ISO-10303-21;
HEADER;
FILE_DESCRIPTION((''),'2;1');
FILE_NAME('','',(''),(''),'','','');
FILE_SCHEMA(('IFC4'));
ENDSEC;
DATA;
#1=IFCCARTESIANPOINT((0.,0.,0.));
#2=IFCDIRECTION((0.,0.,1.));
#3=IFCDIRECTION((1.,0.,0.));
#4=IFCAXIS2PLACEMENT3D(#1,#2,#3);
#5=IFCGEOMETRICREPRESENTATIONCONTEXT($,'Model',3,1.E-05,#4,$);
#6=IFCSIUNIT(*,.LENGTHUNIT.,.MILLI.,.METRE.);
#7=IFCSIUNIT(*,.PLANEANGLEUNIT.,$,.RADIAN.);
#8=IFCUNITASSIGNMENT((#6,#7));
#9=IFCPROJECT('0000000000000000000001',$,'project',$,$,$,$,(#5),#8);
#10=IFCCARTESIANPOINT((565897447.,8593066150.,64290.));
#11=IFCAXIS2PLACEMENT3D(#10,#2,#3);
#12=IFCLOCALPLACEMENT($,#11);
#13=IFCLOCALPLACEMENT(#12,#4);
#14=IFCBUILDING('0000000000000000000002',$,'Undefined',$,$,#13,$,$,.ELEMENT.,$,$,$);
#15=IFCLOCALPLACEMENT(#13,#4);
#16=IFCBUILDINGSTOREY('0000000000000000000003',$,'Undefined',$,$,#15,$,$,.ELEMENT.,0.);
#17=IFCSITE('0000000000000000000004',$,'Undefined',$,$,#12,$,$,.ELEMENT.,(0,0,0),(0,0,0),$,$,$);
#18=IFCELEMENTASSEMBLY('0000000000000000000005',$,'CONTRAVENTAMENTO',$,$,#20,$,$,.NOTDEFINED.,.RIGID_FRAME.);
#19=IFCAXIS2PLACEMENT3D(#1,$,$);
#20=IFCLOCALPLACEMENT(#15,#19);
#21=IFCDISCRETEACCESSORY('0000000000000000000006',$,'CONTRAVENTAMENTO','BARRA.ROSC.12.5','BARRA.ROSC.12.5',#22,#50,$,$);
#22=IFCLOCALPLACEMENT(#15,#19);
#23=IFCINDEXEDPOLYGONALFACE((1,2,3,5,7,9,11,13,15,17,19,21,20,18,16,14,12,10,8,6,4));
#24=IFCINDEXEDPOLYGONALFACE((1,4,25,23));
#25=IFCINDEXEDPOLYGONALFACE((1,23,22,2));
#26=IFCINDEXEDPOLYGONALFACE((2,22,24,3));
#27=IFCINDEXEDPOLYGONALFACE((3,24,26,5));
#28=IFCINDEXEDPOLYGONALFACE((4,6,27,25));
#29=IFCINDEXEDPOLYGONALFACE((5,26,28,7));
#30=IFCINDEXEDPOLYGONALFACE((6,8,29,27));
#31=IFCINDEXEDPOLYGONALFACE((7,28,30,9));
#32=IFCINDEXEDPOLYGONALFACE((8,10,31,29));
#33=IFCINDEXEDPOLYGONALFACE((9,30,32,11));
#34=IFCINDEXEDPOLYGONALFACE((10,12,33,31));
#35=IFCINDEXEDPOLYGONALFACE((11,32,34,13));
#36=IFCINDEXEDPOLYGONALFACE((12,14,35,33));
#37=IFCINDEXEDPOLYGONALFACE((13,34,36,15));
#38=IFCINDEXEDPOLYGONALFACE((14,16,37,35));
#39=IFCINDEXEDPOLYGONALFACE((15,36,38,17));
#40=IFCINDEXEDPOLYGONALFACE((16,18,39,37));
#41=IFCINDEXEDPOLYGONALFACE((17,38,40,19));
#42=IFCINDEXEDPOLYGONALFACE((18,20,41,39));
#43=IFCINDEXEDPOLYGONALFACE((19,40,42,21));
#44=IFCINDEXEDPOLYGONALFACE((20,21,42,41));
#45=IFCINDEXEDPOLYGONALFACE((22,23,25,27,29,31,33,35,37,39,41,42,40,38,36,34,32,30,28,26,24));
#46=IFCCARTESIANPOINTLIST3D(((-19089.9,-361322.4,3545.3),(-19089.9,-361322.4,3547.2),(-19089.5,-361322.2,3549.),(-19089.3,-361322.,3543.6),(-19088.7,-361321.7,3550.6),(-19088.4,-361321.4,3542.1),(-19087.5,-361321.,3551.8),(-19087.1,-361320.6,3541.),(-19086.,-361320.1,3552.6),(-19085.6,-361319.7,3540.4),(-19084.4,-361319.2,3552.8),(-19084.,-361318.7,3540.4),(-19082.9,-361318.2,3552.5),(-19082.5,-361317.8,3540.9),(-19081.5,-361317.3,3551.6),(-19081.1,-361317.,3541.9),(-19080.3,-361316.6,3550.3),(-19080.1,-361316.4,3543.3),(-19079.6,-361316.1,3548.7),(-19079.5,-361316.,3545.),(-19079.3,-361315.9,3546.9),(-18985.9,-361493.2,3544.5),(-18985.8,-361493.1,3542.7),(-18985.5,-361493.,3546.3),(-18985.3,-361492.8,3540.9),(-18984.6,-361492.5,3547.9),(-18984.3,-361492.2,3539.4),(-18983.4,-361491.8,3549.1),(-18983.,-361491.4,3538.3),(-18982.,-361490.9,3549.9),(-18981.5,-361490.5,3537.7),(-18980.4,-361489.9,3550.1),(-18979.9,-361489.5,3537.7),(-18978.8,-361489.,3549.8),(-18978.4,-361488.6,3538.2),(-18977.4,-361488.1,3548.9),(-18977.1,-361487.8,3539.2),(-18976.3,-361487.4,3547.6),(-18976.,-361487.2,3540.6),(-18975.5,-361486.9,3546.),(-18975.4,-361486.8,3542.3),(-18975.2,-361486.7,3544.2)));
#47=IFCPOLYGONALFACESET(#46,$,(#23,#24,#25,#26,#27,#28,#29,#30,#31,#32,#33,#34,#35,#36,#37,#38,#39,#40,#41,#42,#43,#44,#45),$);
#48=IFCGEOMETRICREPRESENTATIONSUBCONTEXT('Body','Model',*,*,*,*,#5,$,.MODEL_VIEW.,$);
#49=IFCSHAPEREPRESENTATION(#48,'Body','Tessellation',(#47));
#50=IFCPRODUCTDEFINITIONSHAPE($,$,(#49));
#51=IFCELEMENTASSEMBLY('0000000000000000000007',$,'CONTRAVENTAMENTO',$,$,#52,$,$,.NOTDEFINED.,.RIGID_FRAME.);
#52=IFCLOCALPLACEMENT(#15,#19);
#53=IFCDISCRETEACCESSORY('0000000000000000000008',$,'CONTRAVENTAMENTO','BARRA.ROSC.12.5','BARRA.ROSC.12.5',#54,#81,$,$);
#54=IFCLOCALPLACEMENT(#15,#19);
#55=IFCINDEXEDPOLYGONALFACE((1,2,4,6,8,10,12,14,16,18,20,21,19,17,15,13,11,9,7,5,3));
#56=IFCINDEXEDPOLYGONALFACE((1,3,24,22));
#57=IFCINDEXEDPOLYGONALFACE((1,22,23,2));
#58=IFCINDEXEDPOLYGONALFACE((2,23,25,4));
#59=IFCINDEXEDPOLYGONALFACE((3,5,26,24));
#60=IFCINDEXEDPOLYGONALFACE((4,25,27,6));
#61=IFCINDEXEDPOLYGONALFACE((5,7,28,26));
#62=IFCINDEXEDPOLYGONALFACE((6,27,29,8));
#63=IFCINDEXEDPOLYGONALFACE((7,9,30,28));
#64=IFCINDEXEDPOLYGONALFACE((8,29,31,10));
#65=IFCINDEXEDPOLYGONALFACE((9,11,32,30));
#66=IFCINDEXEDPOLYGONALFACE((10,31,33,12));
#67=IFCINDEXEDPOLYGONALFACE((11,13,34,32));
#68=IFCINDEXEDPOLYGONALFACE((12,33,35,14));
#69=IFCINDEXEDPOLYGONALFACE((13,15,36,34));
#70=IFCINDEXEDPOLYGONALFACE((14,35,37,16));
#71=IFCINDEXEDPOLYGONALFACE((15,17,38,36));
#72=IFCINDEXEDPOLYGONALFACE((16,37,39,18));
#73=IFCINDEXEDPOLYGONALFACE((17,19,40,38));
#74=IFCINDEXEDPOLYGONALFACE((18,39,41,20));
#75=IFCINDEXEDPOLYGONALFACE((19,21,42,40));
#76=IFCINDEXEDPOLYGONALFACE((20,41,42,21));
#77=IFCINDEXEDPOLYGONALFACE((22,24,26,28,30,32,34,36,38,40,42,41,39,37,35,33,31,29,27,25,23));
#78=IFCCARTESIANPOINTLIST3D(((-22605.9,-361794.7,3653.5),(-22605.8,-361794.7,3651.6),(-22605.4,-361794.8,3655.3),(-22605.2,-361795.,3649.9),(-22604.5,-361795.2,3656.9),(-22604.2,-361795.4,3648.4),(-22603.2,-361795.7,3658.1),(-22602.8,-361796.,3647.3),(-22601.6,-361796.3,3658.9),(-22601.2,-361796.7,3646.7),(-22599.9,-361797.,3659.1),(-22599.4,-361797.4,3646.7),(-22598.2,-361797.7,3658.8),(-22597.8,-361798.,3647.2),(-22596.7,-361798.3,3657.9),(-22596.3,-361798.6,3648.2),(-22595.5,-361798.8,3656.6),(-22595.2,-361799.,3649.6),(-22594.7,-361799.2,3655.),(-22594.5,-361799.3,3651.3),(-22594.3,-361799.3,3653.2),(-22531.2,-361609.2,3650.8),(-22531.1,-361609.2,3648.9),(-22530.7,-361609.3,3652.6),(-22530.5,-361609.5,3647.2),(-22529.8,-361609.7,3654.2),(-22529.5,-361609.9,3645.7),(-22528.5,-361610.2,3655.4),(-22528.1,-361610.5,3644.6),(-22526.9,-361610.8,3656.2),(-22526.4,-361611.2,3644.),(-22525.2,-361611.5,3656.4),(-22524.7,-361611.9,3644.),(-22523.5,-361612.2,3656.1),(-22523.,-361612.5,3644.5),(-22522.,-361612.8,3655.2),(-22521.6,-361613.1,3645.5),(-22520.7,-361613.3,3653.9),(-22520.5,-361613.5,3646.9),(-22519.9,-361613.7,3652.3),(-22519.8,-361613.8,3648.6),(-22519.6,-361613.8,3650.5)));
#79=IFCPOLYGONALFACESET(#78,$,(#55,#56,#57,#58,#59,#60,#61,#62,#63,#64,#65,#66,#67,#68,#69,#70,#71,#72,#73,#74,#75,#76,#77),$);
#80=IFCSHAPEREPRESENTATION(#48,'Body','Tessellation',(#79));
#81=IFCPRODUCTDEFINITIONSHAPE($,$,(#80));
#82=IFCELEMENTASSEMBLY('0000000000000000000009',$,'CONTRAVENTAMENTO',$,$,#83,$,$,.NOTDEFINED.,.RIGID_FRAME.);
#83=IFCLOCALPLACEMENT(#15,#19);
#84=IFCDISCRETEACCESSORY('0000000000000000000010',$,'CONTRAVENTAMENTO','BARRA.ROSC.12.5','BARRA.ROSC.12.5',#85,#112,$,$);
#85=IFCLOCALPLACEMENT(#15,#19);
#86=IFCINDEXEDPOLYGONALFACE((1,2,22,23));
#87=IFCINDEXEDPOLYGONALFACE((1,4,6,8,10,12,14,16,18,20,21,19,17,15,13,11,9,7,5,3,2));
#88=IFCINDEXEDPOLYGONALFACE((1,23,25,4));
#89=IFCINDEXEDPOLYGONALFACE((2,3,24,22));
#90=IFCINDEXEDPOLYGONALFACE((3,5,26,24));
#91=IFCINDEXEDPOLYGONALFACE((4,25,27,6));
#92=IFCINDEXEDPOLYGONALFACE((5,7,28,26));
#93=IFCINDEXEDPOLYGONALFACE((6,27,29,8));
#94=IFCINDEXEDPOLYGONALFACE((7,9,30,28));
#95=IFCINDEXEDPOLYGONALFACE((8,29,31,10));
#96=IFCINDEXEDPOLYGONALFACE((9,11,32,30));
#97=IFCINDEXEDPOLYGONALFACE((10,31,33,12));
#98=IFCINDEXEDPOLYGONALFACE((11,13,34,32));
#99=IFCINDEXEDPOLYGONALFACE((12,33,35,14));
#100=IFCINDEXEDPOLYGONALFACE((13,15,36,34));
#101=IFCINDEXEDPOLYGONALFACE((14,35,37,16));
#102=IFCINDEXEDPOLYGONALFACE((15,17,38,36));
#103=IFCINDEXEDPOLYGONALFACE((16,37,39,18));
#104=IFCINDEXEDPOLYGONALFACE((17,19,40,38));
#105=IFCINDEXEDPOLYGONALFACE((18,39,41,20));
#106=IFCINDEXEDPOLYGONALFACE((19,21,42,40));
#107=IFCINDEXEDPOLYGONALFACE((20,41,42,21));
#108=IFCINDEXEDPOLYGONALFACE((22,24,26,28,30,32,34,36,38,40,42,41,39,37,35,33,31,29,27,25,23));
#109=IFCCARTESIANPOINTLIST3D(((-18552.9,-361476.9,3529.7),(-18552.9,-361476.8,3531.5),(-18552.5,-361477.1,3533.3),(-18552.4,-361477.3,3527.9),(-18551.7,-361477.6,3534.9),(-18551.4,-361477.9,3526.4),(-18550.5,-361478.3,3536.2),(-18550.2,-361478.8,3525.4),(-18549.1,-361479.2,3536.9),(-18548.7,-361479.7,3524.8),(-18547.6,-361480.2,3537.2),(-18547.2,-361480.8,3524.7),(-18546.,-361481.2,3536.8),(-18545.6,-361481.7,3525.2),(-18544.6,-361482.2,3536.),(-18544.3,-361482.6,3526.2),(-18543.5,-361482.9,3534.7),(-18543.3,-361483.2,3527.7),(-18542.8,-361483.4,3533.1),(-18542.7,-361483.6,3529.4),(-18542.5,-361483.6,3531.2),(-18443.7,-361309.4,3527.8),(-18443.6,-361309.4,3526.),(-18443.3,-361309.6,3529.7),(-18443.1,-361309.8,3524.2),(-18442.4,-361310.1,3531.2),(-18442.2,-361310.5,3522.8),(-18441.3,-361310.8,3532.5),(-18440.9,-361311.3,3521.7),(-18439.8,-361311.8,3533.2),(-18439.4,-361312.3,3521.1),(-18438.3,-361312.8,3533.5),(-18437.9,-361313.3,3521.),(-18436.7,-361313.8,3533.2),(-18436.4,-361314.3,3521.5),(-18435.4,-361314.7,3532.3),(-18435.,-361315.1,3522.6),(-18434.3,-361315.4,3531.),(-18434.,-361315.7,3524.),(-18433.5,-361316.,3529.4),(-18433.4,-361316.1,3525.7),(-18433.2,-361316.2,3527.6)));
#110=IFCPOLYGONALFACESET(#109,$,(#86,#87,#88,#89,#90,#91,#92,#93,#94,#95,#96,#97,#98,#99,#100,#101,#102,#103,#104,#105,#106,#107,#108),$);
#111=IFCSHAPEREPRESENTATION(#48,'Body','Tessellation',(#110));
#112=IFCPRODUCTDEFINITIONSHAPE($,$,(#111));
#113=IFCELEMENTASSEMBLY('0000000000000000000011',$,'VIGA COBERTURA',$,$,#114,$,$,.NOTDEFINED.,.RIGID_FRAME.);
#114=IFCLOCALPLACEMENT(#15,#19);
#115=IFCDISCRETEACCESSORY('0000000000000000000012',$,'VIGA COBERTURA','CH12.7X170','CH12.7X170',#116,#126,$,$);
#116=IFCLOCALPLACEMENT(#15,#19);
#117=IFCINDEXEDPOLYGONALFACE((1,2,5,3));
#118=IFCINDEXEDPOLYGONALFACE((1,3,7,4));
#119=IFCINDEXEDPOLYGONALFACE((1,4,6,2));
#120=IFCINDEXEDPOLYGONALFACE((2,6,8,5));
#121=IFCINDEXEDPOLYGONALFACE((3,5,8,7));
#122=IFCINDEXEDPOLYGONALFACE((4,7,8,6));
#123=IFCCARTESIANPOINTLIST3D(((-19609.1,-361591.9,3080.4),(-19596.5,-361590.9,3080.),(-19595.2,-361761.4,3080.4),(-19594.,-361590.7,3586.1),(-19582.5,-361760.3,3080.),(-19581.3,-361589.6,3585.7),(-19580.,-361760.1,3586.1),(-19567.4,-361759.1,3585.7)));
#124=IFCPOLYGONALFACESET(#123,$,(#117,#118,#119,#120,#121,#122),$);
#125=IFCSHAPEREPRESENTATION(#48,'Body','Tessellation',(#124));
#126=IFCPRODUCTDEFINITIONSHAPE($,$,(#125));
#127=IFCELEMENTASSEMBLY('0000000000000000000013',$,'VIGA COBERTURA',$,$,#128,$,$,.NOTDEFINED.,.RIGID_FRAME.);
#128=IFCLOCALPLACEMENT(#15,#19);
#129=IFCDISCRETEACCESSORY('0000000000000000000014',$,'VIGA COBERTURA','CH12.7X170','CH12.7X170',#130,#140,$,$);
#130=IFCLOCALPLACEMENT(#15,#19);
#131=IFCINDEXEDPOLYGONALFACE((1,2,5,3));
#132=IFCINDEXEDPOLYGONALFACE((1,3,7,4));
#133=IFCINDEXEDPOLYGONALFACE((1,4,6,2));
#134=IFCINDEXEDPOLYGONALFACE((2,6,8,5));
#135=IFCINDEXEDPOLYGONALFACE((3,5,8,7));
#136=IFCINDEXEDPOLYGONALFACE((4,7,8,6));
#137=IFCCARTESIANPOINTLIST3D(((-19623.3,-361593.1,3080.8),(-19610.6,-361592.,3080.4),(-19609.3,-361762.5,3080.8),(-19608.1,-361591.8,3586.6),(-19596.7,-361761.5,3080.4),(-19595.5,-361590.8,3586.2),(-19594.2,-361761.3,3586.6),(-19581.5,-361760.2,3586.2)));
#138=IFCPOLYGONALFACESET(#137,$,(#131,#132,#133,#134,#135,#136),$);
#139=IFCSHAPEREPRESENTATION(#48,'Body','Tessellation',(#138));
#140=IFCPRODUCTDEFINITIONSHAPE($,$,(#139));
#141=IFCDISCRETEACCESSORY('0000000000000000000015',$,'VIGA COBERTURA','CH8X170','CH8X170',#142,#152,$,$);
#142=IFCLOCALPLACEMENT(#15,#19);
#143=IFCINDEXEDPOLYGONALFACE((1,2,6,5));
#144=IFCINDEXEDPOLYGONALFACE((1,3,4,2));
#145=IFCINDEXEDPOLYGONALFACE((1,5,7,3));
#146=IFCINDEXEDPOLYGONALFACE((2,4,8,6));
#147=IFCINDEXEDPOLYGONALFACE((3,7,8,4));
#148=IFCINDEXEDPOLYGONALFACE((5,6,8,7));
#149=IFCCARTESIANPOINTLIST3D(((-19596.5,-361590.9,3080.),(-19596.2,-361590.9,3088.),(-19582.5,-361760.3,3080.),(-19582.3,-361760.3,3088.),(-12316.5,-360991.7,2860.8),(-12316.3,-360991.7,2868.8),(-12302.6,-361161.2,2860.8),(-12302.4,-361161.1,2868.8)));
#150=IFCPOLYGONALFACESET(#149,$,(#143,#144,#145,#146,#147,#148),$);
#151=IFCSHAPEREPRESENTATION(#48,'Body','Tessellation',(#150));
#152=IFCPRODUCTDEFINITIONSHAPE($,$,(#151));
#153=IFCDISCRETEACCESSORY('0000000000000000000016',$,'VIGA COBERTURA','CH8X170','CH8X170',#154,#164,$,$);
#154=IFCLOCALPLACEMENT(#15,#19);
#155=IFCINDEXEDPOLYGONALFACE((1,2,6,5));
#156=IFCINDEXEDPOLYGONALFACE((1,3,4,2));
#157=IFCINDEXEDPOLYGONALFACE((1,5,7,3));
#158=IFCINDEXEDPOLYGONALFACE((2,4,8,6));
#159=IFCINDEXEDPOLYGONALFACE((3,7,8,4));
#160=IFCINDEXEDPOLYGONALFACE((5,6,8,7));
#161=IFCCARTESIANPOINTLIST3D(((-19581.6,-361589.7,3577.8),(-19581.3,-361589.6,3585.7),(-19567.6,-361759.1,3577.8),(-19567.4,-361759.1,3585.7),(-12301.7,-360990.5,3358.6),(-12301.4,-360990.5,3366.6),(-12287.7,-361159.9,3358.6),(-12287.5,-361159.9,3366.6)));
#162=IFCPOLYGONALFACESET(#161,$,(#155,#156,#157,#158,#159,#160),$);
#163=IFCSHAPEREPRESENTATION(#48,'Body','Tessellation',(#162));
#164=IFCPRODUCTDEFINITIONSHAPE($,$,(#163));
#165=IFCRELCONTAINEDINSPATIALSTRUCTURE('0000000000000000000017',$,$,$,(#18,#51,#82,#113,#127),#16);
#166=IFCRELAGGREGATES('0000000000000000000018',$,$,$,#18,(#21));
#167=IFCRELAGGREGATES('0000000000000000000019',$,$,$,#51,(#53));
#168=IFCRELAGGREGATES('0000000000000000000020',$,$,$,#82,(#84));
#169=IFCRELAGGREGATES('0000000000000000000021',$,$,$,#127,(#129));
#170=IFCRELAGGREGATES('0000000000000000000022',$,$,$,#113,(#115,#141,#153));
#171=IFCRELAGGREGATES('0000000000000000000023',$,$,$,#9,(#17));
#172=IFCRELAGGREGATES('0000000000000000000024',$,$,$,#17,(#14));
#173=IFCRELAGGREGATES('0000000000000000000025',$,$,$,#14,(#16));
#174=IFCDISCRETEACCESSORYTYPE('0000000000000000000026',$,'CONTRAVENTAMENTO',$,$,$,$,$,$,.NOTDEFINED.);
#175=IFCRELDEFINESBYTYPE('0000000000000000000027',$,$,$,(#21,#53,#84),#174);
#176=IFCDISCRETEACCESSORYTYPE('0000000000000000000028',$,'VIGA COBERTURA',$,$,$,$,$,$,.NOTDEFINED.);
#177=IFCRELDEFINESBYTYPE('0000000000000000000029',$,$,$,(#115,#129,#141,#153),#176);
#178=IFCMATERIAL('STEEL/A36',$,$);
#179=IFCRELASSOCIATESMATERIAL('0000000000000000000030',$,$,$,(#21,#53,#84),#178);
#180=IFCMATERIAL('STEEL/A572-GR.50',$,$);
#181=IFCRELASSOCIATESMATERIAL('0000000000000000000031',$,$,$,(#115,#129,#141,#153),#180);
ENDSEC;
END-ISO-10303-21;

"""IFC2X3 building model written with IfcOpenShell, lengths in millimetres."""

from ifc_helpers import new_model, si_unit, frame, origin_with_axes, origin_2d_with_axis, place, context, subcontext, project, spatial, polyline, rectangle, circle, outline, extrude, material, type_object, element, aggregate, save


model = new_model("IFC2X3")

# Units and contexts
model_context = context("Model", 3, precision=1e-05, world=origin_with_axes())
body_context = subcontext(model_context, "Body", "Model", "MODEL_VIEW")
ifc_project = project(units=[si_unit("LENGTHUNIT", "METRE", prefix="MILLI"), si_unit("PLANEANGLEUNIT", "RADIAN")], contexts=[model_context])

# Site, building, storey
site_placement = place(None, frame((565897447.0, 8593066150.0, 64290.0), z_axis=(0.0, 0.0, 1.0), x_axis=(1.0, 0.0, 0.0)))
site = spatial("IfcSite", under=ifc_project, at=site_placement, Name="Undefined", CompositionType="ELEMENT", RefLatitude=(0, 0, 0), RefLongitude=(0, 0, 0))
building_placement = place(site_placement, origin_with_axes())
building = spatial("IfcBuilding", under=site, at=building_placement, Name="Undefined", CompositionType="ELEMENT")
storey_placement = place(building_placement, origin_with_axes())
storey = spatial("IfcBuildingStorey", under=building, at=storey_placement, Name="Undefined", CompositionType="ELEMENT", Elevation=0.0)

# Shared definitions
ifc_material_1 = material(Name="STEEL/A36")
ifc_material_2 = material(Name="STEEL/A572-GR.50")

# Element assemblies, discrete accessories
assembly_1_placement = place(storey_placement, origin_with_axes())
assembly_1 = element("IfcElementAssembly", 1, at=assembly_1_placement, inside=storey, Name="CONTRAVENTAMENTO", AssemblyPlace="NOTDEFINED", PredefinedType="RIGID_FRAME")
discrete_accessory_type_1 = type_object("IfcDiscreteAccessoryType", Name="CONTRAVENTAMENTO")
discrete_accessory_1_placement = place(assembly_1_placement, frame((-18980.6, -361490.0, 3543.9), z_axis=(-0.853486, -0.520426, 0.026799), x_axis=(-0.520257, 0.853904, 0.013454)))
discrete_accessory_1 = element("IfcDiscreteAccessory", 2, at=discrete_accessory_1_placement, type_object=discrete_accessory_type_1, material=ifc_material_1, Name="CONTRAVENTAMENTO", Description="BARRA.ROSC.12.5", ObjectType="BARRA.ROSC.12.5", context=body_context, shape_type="SweptSolid", body=[
    extrude(circle(Radius=6.2, at=origin_2d_with_axis()), frame((200.0, 0.0, 0.0), z_axis=(-1.0, 0.0, 0.0), x_axis=(0.0, -1.0, 0.0)), (0.0, 0.0, 1.0), 200.0),
])
aggregate(assembly_1, [discrete_accessory_1])
assembly_2_placement = place(storey_placement, origin_with_axes())
assembly_2 = element("IfcElementAssembly", 3, at=assembly_2_placement, inside=storey, Name="CONTRAVENTAMENTO", AssemblyPlace="NOTDEFINED", PredefinedType="RIGID_FRAME")
discrete_accessory_2_placement = place(assembly_2_placement, frame((-22600.1, -361797.0, 3652.9), z_axis=(-0.92709, 0.373879, 0.026799), x_axis=(0.373645, 0.927474, -0.013454)))
discrete_accessory_2 = element("IfcDiscreteAccessory", 4, at=discrete_accessory_2_placement, type_object=discrete_accessory_type_1, material=ifc_material_1, Name="CONTRAVENTAMENTO", Description="BARRA.ROSC.12.5", ObjectType="BARRA.ROSC.12.5", context=body_context, shape_type="SweptSolid", body=[
    extrude(circle(Radius=6.2, at=origin_2d_with_axis()), frame((200.0, 0.0, 0.0), z_axis=(-1.0, 0.0, 0.0), x_axis=(0.0, -1.0, 0.0)), (0.0, 0.0, 1.0), 200.0),
])
aggregate(assembly_2, [discrete_accessory_2])
assembly_3_placement = place(storey_placement, origin_with_axes())
assembly_3 = element("IfcElementAssembly", 5, at=assembly_3_placement, inside=storey, Name="CONTRAVENTAMENTO", AssemblyPlace="NOTDEFINED", PredefinedType="RIGID_FRAME")
discrete_accessory_3_placement = place(assembly_3_placement, frame((-18547.7, -361480.2, 3530.9), z_axis=(-0.836984, 0.546715, 0.02368), x_axis=(0.546411, 0.837315, -0.018398)))
discrete_accessory_3 = element("IfcDiscreteAccessory", 6, at=discrete_accessory_3_placement, type_object=discrete_accessory_type_1, material=ifc_material_1, Name="CONTRAVENTAMENTO", Description="BARRA.ROSC.12.5", ObjectType="BARRA.ROSC.12.5", context=body_context, shape_type="SweptSolid", body=[
    extrude(circle(Radius=6.2, at=origin_2d_with_axis()), frame((200.0, 0.0, 0.0), z_axis=(-1.0, 0.0, 0.0), x_axis=(0.0, -1.0, 0.0)), (0.0, 0.0, 1.0), 200.0),
])
aggregate(assembly_3, [discrete_accessory_3])
assembly_4_placement = place(storey_placement, origin_with_axes())
assembly_4 = element("IfcElementAssembly", 7, at=assembly_4_placement, inside=storey, Name="VIGA COBERTURA", AssemblyPlace="NOTDEFINED", PredefinedType="RIGID_FRAME")
discrete_accessory_type_2 = type_object("IfcDiscreteAccessoryType", Name="VIGA COBERTURA")
discrete_accessory_4_placement = place(assembly_4_placement, frame((-19580.7, -361674.9, 3585.9), z_axis=(-0.082025, 0.99663, 0.0), x_axis=(-0.029885, -0.00246, -0.99955)))
discrete_accessory_4 = element("IfcDiscreteAccessory", 8, at=discrete_accessory_4_placement, type_object=discrete_accessory_type_2, material=ifc_material_2, Name="VIGA COBERTURA", Description="CH12.7X170", ObjectType="CH12.7X170", context=body_context, shape_type="SweptSolid", body=[
    extrude(rectangle(XDim=12.7, YDim=170.0, at=origin_2d_with_axis()), frame((506.0, 0.0, 0.0), z_axis=(-1.0, 0.0, 0.0), x_axis=(0.0, -1.0, 0.0)), (0.0, 0.0, 1.0), 506.0),
])
assembly_5_placement = place(storey_placement, origin_with_axes())
assembly_5 = element("IfcElementAssembly", 9, at=assembly_5_placement, inside=storey, Name="VIGA COBERTURA", AssemblyPlace="NOTDEFINED", PredefinedType="RIGID_FRAME")
discrete_accessory_5_placement = place(assembly_5_placement, frame((-19594.8, -361676.0, 3586.4), z_axis=(-0.082025, 0.99663, 0.0), x_axis=(-0.029885, -0.00246, -0.99955)))
discrete_accessory_5 = element("IfcDiscreteAccessory", 10, at=discrete_accessory_5_placement, type_object=discrete_accessory_type_2, material=ifc_material_2, Name="VIGA COBERTURA", Description="CH12.7X170", ObjectType="CH12.7X170", context=body_context, shape_type="SweptSolid", body=[
    extrude(rectangle(XDim=12.7, YDim=170.0, at=origin_2d_with_axis()), frame((506.0, 0.0, 0.0), z_axis=(-1.0, 0.0, 0.0), x_axis=(0.0, -1.0, 0.0)), (0.0, 0.0, 1.0), 506.0),
])

# Discrete accessories
discrete_accessory_6_placement = place(assembly_4_placement, frame((-19589.4, -361675.6, 3084.0), z_axis=(-0.029885, -0.00246, -0.99955), x_axis=(0.996182, 0.081989, -0.029987)))
discrete_accessory_6 = element("IfcDiscreteAccessory", 11, at=discrete_accessory_6_placement, type_object=discrete_accessory_type_2, material=ifc_material_2, Name="VIGA COBERTURA", Description="CH8X170", ObjectType="CH8X170", context=body_context, shape_type="SweptSolid", body=[
    extrude(outline(polyline([(0.0, -85.0), (0.0, 85.0), (7307.8, 85.0), (7307.8, -85.0), (0.0, -85.0)])), frame((0.0, 0.0, -4.0), z_axis=(0.0, 0.0, 1.0), x_axis=(1.0, 0.0, 0.0)), (0.0, 0.0, 1.0), 8.0),
])
aggregate(assembly_5, [discrete_accessory_5])
discrete_accessory_7_placement = place(assembly_4_placement, frame((-19574.5, -361674.4, 3581.7), z_axis=(-0.029885, -0.00246, -0.99955), x_axis=(0.996182, 0.081989, -0.029987)))
discrete_accessory_7 = element("IfcDiscreteAccessory", 12, at=discrete_accessory_7_placement, type_object=discrete_accessory_type_2, material=ifc_material_2, Name="VIGA COBERTURA", Description="CH8X170", ObjectType="CH8X170", context=body_context, shape_type="SweptSolid", body=[
    extrude(outline(polyline([(0.0, -85.0), (0.0, 85.0), (7307.8, 85.0), (7307.8, -85.0), (0.0, -85.0)])), frame((0.0, 0.0, -4.0), z_axis=(0.0, 0.0, 1.0), x_axis=(1.0, 0.0, 0.0)), (0.0, 0.0, 1.0), 8.0),
])
aggregate(assembly_4, [discrete_accessory_4, discrete_accessory_6, discrete_accessory_7])

save(model, "model.ifc")
